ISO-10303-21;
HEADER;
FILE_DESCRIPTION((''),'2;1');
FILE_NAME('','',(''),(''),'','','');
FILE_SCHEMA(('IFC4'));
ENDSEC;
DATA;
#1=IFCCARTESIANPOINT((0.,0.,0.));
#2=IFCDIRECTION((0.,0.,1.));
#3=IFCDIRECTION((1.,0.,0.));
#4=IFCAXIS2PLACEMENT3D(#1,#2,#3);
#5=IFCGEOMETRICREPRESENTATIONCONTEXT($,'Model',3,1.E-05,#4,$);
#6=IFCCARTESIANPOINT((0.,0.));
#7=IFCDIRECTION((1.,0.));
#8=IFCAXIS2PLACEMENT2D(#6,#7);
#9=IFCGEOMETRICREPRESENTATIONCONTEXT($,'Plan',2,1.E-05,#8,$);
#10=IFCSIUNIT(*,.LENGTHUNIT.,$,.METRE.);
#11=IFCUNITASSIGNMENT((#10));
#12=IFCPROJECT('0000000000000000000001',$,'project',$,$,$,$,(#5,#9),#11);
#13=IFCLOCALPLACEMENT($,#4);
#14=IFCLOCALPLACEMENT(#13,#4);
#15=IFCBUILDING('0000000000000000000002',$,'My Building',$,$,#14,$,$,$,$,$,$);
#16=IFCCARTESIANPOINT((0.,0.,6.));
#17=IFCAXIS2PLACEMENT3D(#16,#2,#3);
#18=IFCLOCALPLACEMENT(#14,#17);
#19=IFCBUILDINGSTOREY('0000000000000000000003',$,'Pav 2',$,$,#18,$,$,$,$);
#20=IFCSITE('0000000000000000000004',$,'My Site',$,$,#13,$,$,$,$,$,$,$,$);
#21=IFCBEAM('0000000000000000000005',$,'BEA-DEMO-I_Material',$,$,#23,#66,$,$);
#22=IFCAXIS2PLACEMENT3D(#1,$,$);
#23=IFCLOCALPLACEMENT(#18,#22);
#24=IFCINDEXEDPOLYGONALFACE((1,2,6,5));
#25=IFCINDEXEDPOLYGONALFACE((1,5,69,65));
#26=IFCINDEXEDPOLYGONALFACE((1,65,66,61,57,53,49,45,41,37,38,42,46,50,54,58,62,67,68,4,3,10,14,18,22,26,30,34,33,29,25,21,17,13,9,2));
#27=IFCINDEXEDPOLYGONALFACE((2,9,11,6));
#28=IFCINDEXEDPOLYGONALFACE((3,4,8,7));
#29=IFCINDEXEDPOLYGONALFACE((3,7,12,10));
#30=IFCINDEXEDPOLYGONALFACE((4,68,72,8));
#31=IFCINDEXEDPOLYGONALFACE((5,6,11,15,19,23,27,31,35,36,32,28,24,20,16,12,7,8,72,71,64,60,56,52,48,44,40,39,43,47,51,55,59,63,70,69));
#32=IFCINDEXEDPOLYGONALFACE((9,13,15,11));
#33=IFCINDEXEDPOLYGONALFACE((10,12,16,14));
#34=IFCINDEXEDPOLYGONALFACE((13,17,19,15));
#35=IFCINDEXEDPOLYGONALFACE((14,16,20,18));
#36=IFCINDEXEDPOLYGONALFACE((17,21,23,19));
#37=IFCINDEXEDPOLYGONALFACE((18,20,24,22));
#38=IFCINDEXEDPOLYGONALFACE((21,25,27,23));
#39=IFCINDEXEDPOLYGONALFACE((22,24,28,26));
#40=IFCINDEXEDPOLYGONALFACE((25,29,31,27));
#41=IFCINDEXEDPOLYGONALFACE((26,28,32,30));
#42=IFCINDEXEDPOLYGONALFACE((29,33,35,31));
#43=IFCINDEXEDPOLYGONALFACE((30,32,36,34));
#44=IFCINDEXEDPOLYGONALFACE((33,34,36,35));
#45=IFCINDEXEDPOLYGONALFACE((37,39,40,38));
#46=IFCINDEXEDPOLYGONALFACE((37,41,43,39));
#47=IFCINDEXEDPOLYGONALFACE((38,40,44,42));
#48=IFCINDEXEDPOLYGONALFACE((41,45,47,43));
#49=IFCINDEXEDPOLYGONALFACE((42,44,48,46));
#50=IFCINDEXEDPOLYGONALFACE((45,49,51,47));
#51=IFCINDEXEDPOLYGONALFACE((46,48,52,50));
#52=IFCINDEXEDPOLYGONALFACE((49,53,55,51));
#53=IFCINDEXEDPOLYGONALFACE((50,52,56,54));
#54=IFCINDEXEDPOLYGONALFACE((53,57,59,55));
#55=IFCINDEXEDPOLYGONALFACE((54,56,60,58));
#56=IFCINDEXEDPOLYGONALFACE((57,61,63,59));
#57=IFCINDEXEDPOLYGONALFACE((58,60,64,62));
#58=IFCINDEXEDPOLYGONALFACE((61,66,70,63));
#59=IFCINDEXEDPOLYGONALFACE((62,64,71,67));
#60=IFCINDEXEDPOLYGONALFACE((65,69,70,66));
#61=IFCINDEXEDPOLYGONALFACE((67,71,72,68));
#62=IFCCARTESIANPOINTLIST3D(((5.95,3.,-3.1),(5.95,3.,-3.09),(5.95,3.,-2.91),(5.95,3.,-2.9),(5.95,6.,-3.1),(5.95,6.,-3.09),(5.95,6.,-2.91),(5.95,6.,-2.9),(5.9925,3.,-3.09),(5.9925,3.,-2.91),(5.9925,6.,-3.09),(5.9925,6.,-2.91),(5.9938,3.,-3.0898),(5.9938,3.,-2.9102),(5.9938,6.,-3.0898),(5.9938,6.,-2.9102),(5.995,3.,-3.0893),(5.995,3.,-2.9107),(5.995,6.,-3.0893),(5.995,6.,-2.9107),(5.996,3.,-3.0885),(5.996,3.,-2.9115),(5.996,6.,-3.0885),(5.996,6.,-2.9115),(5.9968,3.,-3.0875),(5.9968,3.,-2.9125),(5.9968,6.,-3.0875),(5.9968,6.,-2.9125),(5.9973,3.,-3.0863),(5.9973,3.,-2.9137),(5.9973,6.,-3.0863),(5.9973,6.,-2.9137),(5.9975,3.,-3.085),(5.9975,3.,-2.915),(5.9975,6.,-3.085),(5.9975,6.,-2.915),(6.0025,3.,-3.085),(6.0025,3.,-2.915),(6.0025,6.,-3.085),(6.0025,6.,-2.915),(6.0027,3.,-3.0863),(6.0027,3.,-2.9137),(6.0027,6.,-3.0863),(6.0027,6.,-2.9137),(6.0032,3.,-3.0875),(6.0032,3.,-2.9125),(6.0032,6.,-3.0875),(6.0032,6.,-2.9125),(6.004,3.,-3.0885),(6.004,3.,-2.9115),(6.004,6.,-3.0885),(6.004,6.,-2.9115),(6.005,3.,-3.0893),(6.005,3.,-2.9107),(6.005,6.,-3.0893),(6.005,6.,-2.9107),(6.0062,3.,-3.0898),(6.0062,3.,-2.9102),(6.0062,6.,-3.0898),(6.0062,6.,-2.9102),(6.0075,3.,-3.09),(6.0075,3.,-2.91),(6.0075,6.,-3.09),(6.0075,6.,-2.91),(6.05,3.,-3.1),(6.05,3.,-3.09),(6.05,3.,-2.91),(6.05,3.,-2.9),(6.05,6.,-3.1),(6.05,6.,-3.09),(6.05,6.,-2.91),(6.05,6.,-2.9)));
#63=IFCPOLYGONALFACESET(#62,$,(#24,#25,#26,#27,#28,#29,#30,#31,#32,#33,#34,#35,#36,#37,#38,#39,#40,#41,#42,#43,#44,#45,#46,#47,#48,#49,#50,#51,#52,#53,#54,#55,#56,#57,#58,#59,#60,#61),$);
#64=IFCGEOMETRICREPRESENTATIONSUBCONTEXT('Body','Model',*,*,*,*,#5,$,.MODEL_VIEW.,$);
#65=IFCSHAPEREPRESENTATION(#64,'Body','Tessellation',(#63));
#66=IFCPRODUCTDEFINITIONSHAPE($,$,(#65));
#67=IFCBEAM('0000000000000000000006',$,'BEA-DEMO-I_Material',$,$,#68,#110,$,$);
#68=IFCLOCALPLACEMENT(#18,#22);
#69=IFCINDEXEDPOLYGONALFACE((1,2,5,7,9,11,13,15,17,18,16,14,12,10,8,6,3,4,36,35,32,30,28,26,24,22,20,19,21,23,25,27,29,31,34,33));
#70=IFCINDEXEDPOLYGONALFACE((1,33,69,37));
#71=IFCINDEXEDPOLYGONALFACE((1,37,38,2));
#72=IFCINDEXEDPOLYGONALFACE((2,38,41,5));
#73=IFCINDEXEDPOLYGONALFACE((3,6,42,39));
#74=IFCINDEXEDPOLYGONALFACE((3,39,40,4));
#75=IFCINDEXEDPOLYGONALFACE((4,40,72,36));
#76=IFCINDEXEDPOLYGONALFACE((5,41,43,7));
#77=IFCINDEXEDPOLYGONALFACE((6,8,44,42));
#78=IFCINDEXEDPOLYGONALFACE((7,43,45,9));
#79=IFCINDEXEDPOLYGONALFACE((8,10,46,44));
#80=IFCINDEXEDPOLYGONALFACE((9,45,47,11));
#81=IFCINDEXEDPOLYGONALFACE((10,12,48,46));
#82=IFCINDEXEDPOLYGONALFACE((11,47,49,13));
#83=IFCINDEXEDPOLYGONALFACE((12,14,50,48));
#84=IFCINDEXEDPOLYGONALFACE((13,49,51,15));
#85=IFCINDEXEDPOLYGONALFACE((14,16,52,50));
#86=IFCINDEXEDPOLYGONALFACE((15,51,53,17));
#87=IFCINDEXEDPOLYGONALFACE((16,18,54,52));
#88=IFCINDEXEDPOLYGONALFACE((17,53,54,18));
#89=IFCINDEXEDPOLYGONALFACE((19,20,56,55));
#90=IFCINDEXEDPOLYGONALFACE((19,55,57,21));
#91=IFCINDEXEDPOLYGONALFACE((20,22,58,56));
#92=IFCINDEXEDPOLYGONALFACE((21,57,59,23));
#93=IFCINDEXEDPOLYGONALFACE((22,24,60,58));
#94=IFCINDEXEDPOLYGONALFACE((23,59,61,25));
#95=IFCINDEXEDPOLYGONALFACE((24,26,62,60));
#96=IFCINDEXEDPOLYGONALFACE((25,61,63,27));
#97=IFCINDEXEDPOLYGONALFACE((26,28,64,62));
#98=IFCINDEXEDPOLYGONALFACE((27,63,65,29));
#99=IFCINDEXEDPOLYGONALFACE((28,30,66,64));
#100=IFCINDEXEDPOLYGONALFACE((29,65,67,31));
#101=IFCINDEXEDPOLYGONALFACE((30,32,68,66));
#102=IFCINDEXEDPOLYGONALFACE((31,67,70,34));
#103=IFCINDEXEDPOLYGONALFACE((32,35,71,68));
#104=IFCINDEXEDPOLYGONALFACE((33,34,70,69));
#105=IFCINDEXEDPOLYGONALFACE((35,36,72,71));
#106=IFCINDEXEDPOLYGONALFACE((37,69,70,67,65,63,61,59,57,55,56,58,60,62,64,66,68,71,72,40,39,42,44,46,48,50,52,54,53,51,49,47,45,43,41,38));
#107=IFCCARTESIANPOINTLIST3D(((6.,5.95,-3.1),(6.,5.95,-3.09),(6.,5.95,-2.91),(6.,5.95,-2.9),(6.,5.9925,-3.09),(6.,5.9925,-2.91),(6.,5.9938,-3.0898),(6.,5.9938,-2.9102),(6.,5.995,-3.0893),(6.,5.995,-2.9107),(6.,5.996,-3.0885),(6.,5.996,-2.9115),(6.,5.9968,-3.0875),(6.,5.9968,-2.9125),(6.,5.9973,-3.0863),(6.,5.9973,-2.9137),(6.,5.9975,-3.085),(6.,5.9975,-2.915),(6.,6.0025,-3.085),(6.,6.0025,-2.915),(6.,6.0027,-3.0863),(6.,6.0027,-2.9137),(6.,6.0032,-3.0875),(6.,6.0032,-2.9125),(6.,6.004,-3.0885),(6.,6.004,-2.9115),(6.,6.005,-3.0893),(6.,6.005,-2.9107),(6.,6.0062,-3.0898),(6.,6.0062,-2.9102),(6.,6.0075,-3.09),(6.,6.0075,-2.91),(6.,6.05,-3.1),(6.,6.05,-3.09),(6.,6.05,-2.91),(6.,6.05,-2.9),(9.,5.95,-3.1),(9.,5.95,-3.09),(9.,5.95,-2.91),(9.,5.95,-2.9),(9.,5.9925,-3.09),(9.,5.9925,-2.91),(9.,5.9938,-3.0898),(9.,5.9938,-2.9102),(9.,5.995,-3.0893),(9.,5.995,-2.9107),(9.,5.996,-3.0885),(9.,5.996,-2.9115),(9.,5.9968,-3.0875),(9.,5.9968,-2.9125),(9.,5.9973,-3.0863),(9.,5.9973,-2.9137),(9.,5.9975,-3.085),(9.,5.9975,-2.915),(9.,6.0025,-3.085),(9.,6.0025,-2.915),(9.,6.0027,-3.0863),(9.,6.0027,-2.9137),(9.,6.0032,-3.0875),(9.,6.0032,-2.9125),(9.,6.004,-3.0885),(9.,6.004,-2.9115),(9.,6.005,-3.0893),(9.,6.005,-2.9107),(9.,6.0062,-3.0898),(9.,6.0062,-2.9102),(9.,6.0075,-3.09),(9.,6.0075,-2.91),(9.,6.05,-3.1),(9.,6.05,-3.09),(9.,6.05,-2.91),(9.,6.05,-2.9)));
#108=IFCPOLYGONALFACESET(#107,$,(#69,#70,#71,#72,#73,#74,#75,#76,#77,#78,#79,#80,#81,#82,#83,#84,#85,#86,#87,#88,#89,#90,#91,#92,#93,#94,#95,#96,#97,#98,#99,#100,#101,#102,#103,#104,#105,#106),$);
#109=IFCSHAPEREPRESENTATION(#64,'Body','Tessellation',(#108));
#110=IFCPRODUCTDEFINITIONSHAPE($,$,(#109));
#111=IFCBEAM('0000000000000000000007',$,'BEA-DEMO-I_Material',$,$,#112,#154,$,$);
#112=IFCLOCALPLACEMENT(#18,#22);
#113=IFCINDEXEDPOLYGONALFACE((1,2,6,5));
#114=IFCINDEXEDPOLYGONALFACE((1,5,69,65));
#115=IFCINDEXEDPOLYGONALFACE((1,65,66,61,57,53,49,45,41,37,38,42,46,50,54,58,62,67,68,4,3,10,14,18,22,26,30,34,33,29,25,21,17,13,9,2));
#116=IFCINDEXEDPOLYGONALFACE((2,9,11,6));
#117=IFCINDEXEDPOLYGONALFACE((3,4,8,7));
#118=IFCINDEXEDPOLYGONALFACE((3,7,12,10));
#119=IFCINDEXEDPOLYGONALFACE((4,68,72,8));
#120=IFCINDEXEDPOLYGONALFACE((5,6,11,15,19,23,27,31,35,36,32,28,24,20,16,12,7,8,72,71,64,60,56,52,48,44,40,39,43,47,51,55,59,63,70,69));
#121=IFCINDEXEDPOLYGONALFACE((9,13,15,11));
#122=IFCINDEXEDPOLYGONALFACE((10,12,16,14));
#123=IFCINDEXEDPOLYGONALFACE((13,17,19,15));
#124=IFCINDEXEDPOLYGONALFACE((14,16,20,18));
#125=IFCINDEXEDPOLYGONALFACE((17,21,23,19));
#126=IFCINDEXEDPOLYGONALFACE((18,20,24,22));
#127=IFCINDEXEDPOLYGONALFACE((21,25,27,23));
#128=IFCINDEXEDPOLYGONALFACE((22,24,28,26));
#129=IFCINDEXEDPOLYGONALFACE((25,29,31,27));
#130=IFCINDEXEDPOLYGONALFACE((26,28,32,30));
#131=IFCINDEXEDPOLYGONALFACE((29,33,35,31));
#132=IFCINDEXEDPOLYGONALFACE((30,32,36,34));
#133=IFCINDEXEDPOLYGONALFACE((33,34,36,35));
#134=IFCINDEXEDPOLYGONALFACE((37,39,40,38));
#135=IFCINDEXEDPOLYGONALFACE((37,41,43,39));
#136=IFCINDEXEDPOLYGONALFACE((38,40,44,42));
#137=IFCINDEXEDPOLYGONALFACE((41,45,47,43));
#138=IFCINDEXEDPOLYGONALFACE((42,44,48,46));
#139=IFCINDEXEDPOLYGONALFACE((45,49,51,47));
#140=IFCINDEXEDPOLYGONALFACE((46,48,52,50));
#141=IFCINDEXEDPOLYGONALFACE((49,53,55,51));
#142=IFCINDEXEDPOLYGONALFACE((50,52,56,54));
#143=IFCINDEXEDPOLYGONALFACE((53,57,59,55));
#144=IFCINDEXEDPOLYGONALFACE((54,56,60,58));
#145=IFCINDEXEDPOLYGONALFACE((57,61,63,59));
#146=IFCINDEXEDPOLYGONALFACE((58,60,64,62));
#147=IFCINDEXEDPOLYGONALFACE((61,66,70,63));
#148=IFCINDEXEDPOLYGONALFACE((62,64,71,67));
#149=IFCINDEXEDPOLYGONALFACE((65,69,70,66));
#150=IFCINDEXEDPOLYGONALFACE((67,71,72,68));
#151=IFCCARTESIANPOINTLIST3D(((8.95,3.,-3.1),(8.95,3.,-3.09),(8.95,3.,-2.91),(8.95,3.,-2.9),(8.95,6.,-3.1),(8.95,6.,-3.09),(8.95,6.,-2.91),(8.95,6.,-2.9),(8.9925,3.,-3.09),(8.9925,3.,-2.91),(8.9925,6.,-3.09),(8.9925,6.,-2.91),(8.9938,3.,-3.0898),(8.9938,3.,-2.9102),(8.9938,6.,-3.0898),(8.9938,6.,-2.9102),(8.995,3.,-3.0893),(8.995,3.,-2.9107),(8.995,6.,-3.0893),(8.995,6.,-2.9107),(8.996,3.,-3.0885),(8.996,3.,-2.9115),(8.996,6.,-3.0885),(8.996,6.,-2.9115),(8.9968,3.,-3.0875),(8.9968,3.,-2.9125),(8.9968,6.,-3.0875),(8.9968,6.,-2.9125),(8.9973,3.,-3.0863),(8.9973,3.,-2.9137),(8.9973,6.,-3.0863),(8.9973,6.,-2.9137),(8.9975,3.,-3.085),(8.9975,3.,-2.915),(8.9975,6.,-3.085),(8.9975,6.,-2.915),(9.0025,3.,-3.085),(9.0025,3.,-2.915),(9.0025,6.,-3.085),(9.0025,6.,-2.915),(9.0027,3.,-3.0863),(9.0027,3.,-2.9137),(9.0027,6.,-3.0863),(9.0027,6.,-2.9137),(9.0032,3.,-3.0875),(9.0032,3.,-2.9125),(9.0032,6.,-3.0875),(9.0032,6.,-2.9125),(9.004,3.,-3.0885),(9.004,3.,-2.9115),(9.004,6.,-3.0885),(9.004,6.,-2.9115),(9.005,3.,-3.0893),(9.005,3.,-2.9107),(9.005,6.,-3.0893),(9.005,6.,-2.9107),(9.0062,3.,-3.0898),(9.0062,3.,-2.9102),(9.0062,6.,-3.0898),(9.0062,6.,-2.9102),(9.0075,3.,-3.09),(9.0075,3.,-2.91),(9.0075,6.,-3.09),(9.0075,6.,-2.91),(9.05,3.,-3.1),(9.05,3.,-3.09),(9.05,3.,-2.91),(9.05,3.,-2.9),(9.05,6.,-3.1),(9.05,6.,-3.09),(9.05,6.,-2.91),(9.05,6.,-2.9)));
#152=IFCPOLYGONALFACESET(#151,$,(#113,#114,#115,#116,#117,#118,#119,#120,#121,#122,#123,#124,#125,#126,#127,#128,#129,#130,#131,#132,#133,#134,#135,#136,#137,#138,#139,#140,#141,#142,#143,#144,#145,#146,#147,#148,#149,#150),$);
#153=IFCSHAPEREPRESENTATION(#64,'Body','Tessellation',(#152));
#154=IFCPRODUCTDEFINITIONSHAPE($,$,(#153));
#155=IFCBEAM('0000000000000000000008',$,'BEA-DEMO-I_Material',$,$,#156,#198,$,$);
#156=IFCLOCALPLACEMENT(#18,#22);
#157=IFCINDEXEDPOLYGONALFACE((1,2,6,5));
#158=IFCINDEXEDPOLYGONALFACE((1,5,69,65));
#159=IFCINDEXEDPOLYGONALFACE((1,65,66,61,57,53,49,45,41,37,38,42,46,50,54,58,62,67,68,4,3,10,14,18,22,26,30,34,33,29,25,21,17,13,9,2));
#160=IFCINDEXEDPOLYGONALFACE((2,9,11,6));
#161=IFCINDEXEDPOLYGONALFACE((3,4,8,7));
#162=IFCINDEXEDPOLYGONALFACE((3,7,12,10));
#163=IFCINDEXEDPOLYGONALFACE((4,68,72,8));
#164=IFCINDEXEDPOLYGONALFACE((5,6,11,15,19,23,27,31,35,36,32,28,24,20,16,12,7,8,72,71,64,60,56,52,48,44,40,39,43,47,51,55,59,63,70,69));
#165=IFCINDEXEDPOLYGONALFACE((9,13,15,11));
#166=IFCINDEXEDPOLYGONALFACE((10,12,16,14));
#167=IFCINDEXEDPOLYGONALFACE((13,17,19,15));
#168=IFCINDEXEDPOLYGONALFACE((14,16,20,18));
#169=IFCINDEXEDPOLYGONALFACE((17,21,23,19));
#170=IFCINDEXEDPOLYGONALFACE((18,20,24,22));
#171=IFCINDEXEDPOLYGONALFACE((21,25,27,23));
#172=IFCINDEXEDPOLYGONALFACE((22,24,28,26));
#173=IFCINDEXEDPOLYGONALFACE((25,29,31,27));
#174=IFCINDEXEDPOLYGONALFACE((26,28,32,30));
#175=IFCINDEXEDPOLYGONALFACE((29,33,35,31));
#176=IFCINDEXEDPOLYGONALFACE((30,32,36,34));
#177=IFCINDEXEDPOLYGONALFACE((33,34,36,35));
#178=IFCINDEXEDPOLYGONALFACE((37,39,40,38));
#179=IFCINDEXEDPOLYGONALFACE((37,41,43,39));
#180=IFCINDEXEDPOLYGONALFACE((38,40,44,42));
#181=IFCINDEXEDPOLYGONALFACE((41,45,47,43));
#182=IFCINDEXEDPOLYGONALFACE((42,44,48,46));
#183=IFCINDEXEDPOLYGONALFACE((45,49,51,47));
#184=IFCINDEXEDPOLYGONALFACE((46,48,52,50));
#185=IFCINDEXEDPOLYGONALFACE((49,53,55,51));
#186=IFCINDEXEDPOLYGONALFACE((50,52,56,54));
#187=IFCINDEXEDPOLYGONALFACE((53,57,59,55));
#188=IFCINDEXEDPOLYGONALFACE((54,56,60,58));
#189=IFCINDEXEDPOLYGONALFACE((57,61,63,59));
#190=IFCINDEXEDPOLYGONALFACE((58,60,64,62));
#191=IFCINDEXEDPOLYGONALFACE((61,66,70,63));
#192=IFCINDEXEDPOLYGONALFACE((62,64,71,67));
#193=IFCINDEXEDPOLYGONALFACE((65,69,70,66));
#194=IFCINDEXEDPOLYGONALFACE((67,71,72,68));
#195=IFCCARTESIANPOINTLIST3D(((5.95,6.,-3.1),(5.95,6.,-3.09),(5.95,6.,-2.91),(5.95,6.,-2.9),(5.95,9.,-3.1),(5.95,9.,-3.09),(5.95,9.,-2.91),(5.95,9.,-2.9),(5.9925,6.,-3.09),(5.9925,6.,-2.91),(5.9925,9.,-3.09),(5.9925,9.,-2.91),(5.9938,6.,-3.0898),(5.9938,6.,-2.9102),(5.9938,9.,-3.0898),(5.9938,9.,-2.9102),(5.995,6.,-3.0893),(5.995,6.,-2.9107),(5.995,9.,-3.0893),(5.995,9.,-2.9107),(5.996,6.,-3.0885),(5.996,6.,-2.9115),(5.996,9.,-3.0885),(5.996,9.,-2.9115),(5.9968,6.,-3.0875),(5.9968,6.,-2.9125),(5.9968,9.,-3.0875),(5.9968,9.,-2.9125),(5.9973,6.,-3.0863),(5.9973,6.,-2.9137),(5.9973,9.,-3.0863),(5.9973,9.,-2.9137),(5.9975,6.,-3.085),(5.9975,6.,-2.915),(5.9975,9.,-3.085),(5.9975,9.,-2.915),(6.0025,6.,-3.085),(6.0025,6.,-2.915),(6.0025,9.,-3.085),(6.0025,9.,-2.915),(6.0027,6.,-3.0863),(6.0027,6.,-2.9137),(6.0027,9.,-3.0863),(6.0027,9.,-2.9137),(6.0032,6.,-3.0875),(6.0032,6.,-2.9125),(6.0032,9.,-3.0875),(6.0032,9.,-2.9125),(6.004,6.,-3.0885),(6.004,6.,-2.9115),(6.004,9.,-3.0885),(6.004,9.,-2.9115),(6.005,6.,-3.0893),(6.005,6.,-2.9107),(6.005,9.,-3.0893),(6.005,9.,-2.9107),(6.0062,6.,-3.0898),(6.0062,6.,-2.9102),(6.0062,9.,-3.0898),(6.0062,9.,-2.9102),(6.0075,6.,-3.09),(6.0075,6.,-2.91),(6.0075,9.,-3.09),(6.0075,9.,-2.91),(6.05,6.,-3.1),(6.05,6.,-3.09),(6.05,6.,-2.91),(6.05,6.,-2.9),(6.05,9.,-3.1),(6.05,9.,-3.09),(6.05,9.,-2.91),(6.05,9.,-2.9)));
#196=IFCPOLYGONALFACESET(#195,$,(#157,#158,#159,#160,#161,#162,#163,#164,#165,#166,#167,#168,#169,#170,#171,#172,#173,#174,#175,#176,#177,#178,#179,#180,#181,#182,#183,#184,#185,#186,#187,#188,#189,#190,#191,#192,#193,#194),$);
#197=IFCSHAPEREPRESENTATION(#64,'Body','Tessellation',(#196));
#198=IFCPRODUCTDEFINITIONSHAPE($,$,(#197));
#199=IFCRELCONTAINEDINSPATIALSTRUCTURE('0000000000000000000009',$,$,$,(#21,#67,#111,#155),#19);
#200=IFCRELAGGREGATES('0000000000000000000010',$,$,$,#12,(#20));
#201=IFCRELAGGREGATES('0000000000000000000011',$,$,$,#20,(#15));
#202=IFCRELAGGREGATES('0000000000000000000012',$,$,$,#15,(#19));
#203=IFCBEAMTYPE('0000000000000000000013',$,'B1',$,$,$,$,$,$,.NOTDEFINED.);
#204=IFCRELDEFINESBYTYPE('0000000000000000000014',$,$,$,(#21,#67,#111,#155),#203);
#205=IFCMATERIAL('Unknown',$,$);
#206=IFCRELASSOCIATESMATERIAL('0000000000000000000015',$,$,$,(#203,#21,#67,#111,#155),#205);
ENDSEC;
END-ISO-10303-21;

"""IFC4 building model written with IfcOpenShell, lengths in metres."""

from ifc_helpers import new_model, si_unit, frame, origin, origin_with_axes, origin_2d_with_axis, place, context, subcontext, project, spatial, i_section, extrude, material, material_profile, profile_set, profile_usage, type_object, element, save


model = new_model("IFC4")

# Units and contexts
model_context = context("Model", 3, precision=1e-05, world=origin_with_axes())
plan_context = context("Plan", 2, precision=1e-05, world=origin_2d_with_axis())
body_context = subcontext(model_context, "Body", "Model", "MODEL_VIEW")
ifc_project = project(units=[si_unit("LENGTHUNIT", "METRE")], contexts=[model_context, plan_context])

# Site, building, storey
site_placement = place(None, origin_with_axes())
site = spatial("IfcSite", under=ifc_project, at=site_placement, Name="My Site")
building_placement = place(site_placement, origin_with_axes())
building = spatial("IfcBuilding", under=site, at=building_placement, Name="My Building")
storey_placement = place(building_placement, frame((0.0, 0.0, 6.0), z_axis=(0.0, 0.0, 1.0), x_axis=(1.0, 0.0, 0.0)))
storey = spatial("IfcBuildingStorey", under=building, at=storey_placement, Name="Pav 2")

# Beams
ifc_material = material(Name="Unknown")
ifc_material_profile = material_profile(ifc_material, i_section(OverallWidth=0.1, OverallDepth=0.2, WebThickness=0.005, FlangeThickness=0.01, FilletRadius=0.005))
ifc_profile_set = profile_set([ifc_material_profile])
ifc_profile_usage_1 = profile_usage(ifc_profile_set, cardinal=5)
beam_type = type_object("IfcBeamType", Name="B1", PredefinedType="NOTDEFINED", material=ifc_profile_set)
beam_1_placement = place(storey_placement, frame((6.0, 6.0, -3.0), z_axis=(0.0, -1.0, 0.0), x_axis=(1.0, 0.0, 0.0)))
element("IfcBeam", 1, at=beam_1_placement, inside=storey, type_object=beam_type, material=ifc_profile_usage_1, Name="BEA-DEMO-I_Material", context=body_context, shape_type="SweptSolid", body=[
    extrude(i_section(OverallWidth=0.1, OverallDepth=0.2, WebThickness=0.005, FlangeThickness=0.01, FilletRadius=0.005), origin(), (0.0, 0.0, 1.0), 3.0),
])
ifc_profile_usage_2 = profile_usage(ifc_profile_set, cardinal=5)
beam_2_placement = place(storey_placement, frame((6.0, 6.0, -3.0), z_axis=(1.0, 0.0, 0.0), x_axis=(0.0, 1.0, 0.0)))
element("IfcBeam", 2, at=beam_2_placement, inside=storey, type_object=beam_type, material=ifc_profile_usage_2, Name="BEA-DEMO-I_Material", context=body_context, shape_type="SweptSolid", body=[
    extrude(i_section(OverallWidth=0.1, OverallDepth=0.2, WebThickness=0.005, FlangeThickness=0.01, FilletRadius=0.005), origin(), (0.0, 0.0, 1.0), 3.0),
])
ifc_profile_usage_3 = profile_usage(ifc_profile_set, cardinal=5)
beam_3_placement = place(storey_placement, frame((9.0, 6.0, -3.0), z_axis=(0.0, -1.0, 0.0), x_axis=(1.0, 0.0, 0.0)))
element("IfcBeam", 3, at=beam_3_placement, inside=storey, type_object=beam_type, material=ifc_profile_usage_3, Name="BEA-DEMO-I_Material", context=body_context, shape_type="SweptSolid", body=[
    extrude(i_section(OverallWidth=0.1, OverallDepth=0.2, WebThickness=0.005, FlangeThickness=0.01, FilletRadius=0.005), origin(), (0.0, 0.0, 1.0), 3.0),
])
ifc_profile_usage_4 = profile_usage(ifc_profile_set, cardinal=5)
beam_4_placement = place(storey_placement, frame((6.0, 9.0, -3.0), z_axis=(0.0, -1.0, 0.0), x_axis=(1.0, 0.0, 0.0)))
element("IfcBeam", 4, at=beam_4_placement, inside=storey, type_object=beam_type, material=ifc_profile_usage_4, Name="BEA-DEMO-I_Material", context=body_context, shape_type="SweptSolid", body=[
    extrude(i_section(OverallWidth=0.1, OverallDepth=0.2, WebThickness=0.005, FlangeThickness=0.01, FilletRadius=0.005), origin(), (0.0, 0.0, 1.0), 3.0),
])

save(model, "model.ifc")
